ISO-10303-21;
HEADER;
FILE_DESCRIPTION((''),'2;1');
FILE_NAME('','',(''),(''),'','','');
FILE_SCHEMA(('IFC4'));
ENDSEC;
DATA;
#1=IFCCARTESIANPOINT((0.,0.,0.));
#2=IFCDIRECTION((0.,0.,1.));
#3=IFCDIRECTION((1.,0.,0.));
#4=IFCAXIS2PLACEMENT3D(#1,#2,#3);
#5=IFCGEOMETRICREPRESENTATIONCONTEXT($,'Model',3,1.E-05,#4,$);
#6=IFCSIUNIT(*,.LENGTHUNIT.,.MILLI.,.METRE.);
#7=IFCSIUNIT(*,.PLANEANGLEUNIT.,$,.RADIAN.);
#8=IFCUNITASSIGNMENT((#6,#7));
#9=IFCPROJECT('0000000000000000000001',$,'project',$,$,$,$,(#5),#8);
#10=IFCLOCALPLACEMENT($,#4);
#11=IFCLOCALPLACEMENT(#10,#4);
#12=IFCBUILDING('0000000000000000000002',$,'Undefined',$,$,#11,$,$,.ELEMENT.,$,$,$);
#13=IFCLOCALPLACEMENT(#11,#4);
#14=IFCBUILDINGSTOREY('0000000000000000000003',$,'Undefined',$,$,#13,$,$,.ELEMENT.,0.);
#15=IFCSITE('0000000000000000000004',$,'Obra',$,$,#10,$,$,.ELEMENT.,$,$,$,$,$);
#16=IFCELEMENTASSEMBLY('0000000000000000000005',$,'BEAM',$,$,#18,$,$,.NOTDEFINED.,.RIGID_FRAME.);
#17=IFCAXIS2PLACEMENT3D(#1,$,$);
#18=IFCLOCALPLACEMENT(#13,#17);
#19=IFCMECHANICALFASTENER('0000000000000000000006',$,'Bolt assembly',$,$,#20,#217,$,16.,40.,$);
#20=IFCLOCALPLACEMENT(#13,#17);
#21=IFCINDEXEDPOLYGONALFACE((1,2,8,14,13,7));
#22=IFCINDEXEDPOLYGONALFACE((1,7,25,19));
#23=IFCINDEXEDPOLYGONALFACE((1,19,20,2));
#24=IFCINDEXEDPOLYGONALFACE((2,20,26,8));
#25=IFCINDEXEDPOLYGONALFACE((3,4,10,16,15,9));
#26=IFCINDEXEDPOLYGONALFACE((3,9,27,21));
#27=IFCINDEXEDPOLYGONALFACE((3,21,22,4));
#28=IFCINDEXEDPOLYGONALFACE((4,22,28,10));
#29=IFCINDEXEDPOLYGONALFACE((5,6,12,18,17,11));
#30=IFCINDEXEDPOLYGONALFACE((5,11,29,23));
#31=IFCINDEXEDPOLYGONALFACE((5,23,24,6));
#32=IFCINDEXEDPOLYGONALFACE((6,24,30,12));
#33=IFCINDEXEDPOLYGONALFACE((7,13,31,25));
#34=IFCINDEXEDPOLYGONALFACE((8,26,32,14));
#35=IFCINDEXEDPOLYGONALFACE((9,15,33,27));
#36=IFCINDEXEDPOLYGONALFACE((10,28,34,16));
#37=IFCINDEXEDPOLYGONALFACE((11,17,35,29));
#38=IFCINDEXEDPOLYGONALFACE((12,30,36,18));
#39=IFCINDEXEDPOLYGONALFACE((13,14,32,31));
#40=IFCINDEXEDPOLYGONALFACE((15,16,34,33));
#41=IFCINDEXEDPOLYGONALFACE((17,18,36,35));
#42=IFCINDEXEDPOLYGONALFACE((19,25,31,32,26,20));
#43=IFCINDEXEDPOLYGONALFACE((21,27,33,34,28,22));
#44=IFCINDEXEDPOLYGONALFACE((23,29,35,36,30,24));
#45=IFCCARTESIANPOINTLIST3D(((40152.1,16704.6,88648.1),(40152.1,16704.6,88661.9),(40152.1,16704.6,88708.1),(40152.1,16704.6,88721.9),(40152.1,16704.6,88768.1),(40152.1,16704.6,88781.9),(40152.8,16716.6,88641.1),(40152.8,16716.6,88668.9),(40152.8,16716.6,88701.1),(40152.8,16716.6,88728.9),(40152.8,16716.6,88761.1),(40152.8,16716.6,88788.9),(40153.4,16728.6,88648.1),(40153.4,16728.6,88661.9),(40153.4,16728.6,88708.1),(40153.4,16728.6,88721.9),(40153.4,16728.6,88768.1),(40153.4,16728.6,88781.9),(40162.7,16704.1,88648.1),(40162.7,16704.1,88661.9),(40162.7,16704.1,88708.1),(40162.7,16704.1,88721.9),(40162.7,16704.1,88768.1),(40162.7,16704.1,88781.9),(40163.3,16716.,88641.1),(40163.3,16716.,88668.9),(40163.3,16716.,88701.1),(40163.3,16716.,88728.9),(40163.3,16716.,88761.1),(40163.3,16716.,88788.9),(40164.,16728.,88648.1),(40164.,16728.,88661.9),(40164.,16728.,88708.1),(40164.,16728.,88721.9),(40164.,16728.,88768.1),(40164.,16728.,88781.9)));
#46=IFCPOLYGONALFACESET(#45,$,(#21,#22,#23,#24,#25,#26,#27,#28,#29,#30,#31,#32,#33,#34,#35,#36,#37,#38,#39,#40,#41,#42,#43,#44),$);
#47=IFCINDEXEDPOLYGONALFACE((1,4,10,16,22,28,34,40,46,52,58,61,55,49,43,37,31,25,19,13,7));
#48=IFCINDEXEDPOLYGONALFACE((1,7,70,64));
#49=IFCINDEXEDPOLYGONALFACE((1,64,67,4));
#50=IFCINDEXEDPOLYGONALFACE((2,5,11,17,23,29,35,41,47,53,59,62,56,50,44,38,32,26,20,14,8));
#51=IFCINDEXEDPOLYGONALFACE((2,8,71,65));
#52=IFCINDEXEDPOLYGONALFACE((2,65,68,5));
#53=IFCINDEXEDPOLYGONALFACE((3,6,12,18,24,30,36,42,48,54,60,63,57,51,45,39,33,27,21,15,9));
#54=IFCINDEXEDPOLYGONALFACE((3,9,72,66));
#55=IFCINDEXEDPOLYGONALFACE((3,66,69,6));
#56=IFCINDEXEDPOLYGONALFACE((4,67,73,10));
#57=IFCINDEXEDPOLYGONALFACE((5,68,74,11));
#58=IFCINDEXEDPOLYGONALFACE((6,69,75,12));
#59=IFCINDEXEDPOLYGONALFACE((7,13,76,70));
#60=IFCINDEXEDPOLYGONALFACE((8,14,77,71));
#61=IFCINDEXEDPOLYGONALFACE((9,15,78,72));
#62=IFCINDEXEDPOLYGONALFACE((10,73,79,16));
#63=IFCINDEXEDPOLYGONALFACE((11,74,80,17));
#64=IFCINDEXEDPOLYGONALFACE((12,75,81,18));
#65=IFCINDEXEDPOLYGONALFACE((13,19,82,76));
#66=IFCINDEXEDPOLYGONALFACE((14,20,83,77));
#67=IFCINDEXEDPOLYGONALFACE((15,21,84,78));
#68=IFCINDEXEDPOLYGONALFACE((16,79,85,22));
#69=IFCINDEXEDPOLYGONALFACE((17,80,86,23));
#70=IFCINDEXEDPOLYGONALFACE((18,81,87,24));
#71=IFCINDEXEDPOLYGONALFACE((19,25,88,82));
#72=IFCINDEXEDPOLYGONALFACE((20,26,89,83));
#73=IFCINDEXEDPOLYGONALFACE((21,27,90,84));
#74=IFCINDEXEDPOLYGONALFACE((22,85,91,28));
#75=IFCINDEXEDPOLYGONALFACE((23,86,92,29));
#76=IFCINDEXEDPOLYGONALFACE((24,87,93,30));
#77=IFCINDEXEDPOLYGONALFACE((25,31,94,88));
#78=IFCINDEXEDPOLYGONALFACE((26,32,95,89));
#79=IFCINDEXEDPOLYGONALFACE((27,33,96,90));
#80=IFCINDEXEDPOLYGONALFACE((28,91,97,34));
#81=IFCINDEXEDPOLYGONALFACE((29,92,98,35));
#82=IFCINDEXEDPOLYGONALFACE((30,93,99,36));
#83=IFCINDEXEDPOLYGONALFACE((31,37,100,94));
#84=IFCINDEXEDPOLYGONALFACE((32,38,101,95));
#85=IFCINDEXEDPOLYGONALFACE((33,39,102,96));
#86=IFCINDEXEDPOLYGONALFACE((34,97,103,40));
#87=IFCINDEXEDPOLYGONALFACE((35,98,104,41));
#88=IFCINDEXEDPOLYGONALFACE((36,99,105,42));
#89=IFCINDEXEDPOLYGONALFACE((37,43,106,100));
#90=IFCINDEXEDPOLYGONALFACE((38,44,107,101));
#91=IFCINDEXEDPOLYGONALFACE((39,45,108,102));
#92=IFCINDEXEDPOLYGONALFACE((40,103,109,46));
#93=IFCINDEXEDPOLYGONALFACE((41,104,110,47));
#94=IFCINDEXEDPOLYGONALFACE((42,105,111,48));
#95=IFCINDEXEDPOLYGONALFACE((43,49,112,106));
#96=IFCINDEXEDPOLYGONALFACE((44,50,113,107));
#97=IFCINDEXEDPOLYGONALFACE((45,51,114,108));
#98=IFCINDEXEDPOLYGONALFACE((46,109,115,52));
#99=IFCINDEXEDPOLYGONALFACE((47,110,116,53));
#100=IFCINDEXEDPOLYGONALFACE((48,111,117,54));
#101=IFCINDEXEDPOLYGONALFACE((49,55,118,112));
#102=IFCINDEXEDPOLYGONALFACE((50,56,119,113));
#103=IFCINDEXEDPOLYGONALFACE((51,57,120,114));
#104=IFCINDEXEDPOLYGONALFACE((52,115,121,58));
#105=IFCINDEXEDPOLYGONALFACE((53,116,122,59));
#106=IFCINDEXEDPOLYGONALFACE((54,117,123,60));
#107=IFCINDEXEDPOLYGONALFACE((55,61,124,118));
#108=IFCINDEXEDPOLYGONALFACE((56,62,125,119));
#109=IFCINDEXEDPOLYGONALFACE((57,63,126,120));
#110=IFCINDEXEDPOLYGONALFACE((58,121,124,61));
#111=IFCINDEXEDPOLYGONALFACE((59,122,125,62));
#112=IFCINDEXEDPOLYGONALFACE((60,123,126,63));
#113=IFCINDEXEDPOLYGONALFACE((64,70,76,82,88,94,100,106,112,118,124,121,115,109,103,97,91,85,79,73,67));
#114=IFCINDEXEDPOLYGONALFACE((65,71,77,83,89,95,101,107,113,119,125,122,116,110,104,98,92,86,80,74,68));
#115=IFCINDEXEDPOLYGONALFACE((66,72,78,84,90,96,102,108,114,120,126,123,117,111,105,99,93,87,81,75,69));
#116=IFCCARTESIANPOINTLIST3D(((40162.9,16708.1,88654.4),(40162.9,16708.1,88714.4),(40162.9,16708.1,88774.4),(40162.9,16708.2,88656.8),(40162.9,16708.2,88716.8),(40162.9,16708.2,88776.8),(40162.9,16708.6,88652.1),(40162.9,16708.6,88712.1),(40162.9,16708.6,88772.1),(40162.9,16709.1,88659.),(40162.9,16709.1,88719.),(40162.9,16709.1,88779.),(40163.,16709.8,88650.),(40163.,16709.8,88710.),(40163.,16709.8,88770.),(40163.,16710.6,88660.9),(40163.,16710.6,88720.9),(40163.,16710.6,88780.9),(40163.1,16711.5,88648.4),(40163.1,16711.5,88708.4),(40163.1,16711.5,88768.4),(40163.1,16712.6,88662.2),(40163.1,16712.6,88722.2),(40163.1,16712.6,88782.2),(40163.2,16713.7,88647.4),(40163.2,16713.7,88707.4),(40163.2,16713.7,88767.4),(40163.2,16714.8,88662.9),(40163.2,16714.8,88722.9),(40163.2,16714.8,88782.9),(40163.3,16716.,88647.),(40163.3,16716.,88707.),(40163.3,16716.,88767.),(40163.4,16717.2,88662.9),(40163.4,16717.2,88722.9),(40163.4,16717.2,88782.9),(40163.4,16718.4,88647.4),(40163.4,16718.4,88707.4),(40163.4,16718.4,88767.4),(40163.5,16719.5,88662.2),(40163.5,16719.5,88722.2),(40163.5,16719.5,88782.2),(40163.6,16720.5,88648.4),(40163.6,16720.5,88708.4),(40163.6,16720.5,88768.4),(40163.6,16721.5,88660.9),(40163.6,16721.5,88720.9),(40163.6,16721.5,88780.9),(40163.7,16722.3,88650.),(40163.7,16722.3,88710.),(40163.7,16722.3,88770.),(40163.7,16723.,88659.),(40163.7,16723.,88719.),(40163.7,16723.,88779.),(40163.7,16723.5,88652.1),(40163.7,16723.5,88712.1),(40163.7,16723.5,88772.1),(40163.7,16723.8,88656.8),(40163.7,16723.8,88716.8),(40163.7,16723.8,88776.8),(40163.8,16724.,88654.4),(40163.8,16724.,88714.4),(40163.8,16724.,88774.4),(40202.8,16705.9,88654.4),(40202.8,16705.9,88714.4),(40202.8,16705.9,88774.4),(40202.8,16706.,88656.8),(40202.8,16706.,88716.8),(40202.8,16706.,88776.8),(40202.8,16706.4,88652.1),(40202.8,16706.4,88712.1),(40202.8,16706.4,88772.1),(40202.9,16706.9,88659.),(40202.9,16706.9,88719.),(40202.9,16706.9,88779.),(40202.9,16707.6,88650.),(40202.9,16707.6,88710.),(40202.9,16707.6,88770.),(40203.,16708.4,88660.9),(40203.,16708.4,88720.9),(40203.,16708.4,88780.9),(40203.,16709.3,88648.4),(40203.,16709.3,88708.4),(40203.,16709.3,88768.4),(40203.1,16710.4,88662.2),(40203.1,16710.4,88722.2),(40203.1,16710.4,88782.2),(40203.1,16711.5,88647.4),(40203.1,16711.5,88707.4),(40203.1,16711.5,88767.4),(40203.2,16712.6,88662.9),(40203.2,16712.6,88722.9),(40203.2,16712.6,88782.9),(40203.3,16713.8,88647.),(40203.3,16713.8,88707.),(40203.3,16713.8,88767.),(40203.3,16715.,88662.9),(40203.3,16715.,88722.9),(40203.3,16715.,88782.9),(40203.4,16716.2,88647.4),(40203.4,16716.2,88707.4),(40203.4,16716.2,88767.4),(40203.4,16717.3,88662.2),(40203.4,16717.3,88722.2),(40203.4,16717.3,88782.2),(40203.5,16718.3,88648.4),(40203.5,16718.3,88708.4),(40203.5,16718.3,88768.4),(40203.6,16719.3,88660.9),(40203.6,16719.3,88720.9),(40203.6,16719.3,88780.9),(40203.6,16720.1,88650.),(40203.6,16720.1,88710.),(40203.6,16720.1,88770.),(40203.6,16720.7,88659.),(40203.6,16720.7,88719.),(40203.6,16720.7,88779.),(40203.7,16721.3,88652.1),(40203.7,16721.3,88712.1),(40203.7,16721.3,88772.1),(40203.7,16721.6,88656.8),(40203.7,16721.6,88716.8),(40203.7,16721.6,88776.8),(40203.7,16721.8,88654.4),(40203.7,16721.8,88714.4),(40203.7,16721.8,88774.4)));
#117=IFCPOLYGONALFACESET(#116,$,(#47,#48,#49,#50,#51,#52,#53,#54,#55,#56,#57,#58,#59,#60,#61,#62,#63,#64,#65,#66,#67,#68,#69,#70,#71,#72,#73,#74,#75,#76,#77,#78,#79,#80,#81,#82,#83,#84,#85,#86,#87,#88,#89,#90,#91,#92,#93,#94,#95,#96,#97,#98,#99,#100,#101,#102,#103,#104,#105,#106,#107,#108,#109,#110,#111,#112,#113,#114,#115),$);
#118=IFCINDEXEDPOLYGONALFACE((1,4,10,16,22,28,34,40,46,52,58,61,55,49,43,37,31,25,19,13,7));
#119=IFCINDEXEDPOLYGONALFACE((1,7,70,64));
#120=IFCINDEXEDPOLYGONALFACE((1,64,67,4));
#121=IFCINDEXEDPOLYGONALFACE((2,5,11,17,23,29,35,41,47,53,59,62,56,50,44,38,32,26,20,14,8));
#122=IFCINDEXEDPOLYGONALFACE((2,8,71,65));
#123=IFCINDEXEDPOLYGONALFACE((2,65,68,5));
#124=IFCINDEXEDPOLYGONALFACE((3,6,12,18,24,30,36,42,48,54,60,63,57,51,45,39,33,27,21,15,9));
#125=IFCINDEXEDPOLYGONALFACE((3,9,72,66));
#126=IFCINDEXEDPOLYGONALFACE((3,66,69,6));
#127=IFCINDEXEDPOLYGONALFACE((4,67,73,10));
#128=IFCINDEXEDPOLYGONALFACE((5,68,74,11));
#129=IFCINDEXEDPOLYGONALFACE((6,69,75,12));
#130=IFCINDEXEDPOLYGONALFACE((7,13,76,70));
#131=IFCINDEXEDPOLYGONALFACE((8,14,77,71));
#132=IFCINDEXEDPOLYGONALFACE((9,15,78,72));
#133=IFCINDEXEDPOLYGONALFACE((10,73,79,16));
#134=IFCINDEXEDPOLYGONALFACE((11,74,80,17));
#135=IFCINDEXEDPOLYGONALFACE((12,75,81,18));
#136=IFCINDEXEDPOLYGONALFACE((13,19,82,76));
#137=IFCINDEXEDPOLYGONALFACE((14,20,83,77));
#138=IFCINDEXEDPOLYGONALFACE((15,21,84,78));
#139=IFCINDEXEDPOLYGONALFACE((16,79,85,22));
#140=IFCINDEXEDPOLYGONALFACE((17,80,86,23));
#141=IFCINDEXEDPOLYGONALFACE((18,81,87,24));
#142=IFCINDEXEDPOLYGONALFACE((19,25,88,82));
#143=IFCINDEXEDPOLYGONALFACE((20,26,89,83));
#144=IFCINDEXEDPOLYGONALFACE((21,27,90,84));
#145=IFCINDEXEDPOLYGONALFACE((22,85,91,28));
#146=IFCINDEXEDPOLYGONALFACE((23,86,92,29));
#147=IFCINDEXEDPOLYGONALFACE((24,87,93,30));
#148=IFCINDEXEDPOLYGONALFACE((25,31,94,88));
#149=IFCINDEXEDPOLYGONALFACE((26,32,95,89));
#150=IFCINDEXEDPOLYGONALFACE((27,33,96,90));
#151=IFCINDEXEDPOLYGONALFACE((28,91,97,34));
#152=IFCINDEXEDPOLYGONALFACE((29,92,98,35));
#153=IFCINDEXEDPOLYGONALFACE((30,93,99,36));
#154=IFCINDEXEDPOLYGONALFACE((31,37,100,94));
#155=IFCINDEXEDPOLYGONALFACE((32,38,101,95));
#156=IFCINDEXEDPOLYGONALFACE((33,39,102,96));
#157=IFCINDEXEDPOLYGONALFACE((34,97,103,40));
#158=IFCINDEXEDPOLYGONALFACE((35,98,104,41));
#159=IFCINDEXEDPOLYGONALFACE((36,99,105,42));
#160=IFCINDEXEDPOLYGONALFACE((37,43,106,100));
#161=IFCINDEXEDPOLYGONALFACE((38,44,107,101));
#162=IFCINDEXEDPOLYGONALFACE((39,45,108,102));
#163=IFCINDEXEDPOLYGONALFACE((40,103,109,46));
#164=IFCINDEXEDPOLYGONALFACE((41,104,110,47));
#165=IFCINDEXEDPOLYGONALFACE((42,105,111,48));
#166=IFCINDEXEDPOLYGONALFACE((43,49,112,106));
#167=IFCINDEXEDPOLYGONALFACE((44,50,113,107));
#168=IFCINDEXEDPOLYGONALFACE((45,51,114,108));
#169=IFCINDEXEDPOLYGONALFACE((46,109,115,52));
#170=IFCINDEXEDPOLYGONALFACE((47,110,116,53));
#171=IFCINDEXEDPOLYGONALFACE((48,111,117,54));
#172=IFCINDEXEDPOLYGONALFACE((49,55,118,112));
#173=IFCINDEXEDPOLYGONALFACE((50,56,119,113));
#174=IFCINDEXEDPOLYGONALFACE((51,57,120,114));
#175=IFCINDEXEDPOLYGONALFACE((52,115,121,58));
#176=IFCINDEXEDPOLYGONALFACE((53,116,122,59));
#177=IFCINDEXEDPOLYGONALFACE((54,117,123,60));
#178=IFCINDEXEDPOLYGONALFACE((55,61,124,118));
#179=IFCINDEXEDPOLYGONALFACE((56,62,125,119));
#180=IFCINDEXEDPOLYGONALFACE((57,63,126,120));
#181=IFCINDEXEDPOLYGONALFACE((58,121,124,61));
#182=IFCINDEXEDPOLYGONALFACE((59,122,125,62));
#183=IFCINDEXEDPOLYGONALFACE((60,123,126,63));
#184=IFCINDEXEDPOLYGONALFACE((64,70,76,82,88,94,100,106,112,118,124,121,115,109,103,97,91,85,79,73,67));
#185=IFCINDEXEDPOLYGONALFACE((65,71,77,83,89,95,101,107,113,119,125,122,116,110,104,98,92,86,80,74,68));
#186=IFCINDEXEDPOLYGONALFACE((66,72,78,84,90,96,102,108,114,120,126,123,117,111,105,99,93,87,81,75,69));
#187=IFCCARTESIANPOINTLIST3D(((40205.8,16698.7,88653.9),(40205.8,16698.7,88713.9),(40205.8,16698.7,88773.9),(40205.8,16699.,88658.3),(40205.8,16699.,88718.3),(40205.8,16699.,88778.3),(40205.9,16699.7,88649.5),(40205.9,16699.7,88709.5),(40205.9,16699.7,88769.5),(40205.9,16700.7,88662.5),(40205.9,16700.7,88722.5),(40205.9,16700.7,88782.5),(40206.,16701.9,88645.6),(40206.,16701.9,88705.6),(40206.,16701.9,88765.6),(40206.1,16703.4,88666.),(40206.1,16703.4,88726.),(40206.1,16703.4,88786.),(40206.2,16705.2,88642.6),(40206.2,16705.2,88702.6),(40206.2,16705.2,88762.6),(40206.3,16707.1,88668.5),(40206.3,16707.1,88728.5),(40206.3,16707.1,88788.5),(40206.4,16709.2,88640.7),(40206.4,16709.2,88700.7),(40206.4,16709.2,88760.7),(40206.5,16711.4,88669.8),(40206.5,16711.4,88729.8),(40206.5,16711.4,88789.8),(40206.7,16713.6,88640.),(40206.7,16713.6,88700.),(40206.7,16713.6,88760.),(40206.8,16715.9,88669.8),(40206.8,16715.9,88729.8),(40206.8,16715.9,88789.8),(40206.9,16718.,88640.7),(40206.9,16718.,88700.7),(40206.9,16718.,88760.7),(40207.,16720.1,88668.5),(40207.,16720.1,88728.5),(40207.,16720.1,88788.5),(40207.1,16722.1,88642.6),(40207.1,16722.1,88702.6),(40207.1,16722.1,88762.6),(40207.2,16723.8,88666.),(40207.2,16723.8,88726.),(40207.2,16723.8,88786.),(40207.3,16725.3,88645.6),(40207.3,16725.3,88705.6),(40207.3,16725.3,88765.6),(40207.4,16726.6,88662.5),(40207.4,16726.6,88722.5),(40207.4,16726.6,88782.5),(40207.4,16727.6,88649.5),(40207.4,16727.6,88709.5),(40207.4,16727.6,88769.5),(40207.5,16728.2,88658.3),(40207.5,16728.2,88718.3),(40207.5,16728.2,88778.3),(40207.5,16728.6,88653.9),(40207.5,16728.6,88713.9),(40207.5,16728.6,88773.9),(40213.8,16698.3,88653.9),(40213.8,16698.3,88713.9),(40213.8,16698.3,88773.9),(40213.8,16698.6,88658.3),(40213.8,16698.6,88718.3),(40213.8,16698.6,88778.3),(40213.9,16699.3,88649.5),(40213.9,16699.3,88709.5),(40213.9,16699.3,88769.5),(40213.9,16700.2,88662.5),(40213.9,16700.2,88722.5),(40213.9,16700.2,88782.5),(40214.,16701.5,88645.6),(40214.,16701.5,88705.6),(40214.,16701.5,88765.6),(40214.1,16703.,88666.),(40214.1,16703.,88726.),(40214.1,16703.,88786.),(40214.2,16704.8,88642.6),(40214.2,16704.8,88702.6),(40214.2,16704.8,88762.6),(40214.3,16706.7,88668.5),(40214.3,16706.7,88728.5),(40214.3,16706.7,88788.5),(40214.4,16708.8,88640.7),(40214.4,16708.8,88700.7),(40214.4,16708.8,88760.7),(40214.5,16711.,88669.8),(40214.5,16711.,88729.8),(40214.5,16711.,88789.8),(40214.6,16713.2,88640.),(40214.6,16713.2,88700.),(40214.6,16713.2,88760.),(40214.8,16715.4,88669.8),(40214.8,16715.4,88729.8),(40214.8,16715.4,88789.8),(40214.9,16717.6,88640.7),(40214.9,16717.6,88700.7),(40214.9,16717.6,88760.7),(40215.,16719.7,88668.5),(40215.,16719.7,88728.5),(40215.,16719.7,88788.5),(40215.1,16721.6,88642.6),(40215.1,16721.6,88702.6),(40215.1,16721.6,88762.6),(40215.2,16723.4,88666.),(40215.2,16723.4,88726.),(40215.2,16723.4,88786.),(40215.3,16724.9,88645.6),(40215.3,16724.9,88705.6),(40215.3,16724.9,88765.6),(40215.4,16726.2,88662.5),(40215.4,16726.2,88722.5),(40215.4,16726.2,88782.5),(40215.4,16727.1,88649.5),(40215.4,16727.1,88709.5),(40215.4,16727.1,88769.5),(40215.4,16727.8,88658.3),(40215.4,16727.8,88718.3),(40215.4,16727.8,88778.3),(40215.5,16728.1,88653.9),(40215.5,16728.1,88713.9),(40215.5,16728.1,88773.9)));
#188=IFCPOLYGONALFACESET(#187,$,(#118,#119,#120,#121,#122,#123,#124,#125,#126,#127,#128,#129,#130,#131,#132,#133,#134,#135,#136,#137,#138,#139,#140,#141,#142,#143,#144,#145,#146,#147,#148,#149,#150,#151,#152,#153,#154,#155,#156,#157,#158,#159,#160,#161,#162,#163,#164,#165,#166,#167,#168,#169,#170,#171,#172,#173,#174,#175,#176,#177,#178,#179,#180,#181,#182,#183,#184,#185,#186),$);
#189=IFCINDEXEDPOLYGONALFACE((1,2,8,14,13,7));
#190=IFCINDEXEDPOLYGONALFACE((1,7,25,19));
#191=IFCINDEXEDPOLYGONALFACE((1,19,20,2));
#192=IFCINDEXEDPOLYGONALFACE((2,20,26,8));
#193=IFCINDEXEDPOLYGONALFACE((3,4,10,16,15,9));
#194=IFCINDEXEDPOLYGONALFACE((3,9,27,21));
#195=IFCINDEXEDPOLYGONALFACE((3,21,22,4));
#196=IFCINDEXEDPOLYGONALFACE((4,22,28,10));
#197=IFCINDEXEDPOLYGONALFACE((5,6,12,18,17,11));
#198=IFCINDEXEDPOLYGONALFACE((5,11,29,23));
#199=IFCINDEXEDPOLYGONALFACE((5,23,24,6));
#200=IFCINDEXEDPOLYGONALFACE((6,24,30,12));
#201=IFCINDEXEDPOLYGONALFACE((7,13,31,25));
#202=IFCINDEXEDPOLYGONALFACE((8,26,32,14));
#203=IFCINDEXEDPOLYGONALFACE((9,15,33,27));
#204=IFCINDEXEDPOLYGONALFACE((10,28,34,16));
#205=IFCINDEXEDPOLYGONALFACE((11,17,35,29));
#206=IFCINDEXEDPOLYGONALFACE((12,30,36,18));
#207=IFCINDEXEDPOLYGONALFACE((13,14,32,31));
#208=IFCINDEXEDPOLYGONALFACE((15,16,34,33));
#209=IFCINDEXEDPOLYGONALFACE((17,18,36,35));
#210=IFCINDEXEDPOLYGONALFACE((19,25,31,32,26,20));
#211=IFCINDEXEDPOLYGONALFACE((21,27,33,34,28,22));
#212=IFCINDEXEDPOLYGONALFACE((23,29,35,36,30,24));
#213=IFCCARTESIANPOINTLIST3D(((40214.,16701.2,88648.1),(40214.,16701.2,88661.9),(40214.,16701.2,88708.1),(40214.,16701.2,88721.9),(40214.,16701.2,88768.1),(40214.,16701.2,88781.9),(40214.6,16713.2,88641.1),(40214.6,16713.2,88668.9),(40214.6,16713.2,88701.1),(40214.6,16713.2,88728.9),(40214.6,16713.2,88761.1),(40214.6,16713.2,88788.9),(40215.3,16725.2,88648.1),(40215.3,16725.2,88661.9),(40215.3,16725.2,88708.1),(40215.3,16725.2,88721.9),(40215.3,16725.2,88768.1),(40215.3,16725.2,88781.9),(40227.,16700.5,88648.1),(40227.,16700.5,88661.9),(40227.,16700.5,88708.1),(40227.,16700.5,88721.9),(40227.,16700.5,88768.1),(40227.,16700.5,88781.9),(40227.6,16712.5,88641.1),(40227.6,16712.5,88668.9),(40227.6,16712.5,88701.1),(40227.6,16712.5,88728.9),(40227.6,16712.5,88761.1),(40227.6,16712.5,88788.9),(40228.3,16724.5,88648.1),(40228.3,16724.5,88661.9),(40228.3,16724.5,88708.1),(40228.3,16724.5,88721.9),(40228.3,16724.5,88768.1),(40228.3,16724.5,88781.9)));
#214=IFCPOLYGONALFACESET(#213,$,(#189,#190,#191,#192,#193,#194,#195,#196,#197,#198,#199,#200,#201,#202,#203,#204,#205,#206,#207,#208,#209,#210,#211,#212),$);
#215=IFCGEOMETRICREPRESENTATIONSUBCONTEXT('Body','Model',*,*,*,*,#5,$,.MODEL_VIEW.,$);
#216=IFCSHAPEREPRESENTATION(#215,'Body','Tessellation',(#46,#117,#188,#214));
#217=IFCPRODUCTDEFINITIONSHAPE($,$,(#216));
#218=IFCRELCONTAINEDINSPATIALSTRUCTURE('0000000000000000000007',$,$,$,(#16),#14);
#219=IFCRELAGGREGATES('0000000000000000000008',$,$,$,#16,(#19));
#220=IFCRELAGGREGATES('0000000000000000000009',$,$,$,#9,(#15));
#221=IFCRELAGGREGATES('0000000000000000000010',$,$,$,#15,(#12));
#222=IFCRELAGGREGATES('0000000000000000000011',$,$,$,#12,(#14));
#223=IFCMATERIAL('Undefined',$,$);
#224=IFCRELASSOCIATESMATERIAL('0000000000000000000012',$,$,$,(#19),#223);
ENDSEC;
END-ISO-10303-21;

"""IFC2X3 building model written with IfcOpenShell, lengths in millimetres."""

from ifc_helpers import new_model, si_unit, frame, origin_with_axes, origin_2d_with_axis, place, context, subcontext, project, spatial, polyline, circle, outline, extrude, source, transform, mapped, material, element, aggregate, save


model = new_model("IFC2X3")

# Units and contexts
model_context = context("Model", 3, precision=1e-05, world=origin_with_axes())
body_context = subcontext(model_context, "Body", "Model", "MODEL_VIEW")
ifc_project = project(units=[si_unit("LENGTHUNIT", "METRE", prefix="MILLI"), si_unit("PLANEANGLEUNIT", "RADIAN")], contexts=[model_context])

# Site, building, storey
site_placement = place(None, origin_with_axes())
site = spatial("IfcSite", under=ifc_project, at=site_placement, Name="Obra", CompositionType="ELEMENT")
building_placement = place(site_placement, origin_with_axes())
building = spatial("IfcBuilding", under=site, at=building_placement, Name="Undefined", CompositionType="ELEMENT")
storey_placement = place(building_placement, origin_with_axes())
storey = spatial("IfcBuildingStorey", under=building, at=storey_placement, Name="Undefined", CompositionType="ELEMENT", Elevation=0.0)

# Element assembly, mechanical fastener
ifc_material_1 = material(Name="Undefined")
shared_shape_1 = source(origin_with_axes(), body_context, "Body", "SweptSolid", [
    extrude(outline(polyline([(13.9, 0.0), (6.9, 12.0), (-6.9, 12.0), (-13.9, 0.0), (-6.9, -12.0), (6.9, -12.0), (13.9, 0.0)])), frame((0.0, -19.7, 0.0), z_axis=(0.0, 1.0, 0.0), x_axis=(1.0, 0.0, 0.0)), (0.0, 0.0, 1.0), 10.6),
    extrude(circle(Radius=8.0, at=origin_2d_with_axis()), frame((0.0, -9.1, 0.0), z_axis=(0.0, 1.0, 0.0), x_axis=(1.0, 0.0, 0.0)), (0.0, 0.0, 1.0), 40.0),
    extrude(circle(Radius=15.0, at=origin_2d_with_axis()), frame((0.0, 34.3, 0.0), z_axis=(0.0, 1.0, 0.0), x_axis=(1.0, 0.0, 0.0)), (0.0, 0.0, 1.0), 8.0),
    extrude(outline(polyline([(13.9, 0.0), (6.9, 12.0), (-6.9, 12.0), (-13.9, 0.0), (-6.9, -12.0), (6.9, -12.0), (13.9, 0.0)])), frame((0.0, 42.3, 0.0), z_axis=(0.0, 1.0, 0.0), x_axis=(1.0, 0.0, 0.0)), (0.0, 0.0, 1.0), 13.0),
])
assembly_1_placement = place(storey_placement, origin_with_axes())
assembly_1 = element("IfcElementAssembly", 1, at=assembly_1_placement, inside=storey, Name="BEAM", AssemblyPlace="NOTDEFINED", PredefinedType="RIGID_FRAME")
mechanical_fastener_1_placement = place(assembly_1_placement, frame((40175.2, 16765.5, 88835.0), z_axis=(-0.055268, -0.998472, 0.0), x_axis=(0.0, 0.0, -1.0)))
mechanical_fastener_1 = element("IfcMechanicalFastener", 2, at=mechanical_fastener_1_placement, material=ifc_material_1, Name="Bolt assembly", NominalDiameter=16.0, NominalLength=40.0, context=body_context, shape_type="MappedRepresentation", body=[
    mapped(shared_shape_1, transform((60.0, 0.0, 50.0))),
    mapped(shared_shape_1, transform((120.0, 0.0, 50.0))),
    mapped(shared_shape_1, transform((180.0, 0.0, 50.0))),
])
aggregate(assembly_1, [mechanical_fastener_1])

save(model, "model.ifc")
